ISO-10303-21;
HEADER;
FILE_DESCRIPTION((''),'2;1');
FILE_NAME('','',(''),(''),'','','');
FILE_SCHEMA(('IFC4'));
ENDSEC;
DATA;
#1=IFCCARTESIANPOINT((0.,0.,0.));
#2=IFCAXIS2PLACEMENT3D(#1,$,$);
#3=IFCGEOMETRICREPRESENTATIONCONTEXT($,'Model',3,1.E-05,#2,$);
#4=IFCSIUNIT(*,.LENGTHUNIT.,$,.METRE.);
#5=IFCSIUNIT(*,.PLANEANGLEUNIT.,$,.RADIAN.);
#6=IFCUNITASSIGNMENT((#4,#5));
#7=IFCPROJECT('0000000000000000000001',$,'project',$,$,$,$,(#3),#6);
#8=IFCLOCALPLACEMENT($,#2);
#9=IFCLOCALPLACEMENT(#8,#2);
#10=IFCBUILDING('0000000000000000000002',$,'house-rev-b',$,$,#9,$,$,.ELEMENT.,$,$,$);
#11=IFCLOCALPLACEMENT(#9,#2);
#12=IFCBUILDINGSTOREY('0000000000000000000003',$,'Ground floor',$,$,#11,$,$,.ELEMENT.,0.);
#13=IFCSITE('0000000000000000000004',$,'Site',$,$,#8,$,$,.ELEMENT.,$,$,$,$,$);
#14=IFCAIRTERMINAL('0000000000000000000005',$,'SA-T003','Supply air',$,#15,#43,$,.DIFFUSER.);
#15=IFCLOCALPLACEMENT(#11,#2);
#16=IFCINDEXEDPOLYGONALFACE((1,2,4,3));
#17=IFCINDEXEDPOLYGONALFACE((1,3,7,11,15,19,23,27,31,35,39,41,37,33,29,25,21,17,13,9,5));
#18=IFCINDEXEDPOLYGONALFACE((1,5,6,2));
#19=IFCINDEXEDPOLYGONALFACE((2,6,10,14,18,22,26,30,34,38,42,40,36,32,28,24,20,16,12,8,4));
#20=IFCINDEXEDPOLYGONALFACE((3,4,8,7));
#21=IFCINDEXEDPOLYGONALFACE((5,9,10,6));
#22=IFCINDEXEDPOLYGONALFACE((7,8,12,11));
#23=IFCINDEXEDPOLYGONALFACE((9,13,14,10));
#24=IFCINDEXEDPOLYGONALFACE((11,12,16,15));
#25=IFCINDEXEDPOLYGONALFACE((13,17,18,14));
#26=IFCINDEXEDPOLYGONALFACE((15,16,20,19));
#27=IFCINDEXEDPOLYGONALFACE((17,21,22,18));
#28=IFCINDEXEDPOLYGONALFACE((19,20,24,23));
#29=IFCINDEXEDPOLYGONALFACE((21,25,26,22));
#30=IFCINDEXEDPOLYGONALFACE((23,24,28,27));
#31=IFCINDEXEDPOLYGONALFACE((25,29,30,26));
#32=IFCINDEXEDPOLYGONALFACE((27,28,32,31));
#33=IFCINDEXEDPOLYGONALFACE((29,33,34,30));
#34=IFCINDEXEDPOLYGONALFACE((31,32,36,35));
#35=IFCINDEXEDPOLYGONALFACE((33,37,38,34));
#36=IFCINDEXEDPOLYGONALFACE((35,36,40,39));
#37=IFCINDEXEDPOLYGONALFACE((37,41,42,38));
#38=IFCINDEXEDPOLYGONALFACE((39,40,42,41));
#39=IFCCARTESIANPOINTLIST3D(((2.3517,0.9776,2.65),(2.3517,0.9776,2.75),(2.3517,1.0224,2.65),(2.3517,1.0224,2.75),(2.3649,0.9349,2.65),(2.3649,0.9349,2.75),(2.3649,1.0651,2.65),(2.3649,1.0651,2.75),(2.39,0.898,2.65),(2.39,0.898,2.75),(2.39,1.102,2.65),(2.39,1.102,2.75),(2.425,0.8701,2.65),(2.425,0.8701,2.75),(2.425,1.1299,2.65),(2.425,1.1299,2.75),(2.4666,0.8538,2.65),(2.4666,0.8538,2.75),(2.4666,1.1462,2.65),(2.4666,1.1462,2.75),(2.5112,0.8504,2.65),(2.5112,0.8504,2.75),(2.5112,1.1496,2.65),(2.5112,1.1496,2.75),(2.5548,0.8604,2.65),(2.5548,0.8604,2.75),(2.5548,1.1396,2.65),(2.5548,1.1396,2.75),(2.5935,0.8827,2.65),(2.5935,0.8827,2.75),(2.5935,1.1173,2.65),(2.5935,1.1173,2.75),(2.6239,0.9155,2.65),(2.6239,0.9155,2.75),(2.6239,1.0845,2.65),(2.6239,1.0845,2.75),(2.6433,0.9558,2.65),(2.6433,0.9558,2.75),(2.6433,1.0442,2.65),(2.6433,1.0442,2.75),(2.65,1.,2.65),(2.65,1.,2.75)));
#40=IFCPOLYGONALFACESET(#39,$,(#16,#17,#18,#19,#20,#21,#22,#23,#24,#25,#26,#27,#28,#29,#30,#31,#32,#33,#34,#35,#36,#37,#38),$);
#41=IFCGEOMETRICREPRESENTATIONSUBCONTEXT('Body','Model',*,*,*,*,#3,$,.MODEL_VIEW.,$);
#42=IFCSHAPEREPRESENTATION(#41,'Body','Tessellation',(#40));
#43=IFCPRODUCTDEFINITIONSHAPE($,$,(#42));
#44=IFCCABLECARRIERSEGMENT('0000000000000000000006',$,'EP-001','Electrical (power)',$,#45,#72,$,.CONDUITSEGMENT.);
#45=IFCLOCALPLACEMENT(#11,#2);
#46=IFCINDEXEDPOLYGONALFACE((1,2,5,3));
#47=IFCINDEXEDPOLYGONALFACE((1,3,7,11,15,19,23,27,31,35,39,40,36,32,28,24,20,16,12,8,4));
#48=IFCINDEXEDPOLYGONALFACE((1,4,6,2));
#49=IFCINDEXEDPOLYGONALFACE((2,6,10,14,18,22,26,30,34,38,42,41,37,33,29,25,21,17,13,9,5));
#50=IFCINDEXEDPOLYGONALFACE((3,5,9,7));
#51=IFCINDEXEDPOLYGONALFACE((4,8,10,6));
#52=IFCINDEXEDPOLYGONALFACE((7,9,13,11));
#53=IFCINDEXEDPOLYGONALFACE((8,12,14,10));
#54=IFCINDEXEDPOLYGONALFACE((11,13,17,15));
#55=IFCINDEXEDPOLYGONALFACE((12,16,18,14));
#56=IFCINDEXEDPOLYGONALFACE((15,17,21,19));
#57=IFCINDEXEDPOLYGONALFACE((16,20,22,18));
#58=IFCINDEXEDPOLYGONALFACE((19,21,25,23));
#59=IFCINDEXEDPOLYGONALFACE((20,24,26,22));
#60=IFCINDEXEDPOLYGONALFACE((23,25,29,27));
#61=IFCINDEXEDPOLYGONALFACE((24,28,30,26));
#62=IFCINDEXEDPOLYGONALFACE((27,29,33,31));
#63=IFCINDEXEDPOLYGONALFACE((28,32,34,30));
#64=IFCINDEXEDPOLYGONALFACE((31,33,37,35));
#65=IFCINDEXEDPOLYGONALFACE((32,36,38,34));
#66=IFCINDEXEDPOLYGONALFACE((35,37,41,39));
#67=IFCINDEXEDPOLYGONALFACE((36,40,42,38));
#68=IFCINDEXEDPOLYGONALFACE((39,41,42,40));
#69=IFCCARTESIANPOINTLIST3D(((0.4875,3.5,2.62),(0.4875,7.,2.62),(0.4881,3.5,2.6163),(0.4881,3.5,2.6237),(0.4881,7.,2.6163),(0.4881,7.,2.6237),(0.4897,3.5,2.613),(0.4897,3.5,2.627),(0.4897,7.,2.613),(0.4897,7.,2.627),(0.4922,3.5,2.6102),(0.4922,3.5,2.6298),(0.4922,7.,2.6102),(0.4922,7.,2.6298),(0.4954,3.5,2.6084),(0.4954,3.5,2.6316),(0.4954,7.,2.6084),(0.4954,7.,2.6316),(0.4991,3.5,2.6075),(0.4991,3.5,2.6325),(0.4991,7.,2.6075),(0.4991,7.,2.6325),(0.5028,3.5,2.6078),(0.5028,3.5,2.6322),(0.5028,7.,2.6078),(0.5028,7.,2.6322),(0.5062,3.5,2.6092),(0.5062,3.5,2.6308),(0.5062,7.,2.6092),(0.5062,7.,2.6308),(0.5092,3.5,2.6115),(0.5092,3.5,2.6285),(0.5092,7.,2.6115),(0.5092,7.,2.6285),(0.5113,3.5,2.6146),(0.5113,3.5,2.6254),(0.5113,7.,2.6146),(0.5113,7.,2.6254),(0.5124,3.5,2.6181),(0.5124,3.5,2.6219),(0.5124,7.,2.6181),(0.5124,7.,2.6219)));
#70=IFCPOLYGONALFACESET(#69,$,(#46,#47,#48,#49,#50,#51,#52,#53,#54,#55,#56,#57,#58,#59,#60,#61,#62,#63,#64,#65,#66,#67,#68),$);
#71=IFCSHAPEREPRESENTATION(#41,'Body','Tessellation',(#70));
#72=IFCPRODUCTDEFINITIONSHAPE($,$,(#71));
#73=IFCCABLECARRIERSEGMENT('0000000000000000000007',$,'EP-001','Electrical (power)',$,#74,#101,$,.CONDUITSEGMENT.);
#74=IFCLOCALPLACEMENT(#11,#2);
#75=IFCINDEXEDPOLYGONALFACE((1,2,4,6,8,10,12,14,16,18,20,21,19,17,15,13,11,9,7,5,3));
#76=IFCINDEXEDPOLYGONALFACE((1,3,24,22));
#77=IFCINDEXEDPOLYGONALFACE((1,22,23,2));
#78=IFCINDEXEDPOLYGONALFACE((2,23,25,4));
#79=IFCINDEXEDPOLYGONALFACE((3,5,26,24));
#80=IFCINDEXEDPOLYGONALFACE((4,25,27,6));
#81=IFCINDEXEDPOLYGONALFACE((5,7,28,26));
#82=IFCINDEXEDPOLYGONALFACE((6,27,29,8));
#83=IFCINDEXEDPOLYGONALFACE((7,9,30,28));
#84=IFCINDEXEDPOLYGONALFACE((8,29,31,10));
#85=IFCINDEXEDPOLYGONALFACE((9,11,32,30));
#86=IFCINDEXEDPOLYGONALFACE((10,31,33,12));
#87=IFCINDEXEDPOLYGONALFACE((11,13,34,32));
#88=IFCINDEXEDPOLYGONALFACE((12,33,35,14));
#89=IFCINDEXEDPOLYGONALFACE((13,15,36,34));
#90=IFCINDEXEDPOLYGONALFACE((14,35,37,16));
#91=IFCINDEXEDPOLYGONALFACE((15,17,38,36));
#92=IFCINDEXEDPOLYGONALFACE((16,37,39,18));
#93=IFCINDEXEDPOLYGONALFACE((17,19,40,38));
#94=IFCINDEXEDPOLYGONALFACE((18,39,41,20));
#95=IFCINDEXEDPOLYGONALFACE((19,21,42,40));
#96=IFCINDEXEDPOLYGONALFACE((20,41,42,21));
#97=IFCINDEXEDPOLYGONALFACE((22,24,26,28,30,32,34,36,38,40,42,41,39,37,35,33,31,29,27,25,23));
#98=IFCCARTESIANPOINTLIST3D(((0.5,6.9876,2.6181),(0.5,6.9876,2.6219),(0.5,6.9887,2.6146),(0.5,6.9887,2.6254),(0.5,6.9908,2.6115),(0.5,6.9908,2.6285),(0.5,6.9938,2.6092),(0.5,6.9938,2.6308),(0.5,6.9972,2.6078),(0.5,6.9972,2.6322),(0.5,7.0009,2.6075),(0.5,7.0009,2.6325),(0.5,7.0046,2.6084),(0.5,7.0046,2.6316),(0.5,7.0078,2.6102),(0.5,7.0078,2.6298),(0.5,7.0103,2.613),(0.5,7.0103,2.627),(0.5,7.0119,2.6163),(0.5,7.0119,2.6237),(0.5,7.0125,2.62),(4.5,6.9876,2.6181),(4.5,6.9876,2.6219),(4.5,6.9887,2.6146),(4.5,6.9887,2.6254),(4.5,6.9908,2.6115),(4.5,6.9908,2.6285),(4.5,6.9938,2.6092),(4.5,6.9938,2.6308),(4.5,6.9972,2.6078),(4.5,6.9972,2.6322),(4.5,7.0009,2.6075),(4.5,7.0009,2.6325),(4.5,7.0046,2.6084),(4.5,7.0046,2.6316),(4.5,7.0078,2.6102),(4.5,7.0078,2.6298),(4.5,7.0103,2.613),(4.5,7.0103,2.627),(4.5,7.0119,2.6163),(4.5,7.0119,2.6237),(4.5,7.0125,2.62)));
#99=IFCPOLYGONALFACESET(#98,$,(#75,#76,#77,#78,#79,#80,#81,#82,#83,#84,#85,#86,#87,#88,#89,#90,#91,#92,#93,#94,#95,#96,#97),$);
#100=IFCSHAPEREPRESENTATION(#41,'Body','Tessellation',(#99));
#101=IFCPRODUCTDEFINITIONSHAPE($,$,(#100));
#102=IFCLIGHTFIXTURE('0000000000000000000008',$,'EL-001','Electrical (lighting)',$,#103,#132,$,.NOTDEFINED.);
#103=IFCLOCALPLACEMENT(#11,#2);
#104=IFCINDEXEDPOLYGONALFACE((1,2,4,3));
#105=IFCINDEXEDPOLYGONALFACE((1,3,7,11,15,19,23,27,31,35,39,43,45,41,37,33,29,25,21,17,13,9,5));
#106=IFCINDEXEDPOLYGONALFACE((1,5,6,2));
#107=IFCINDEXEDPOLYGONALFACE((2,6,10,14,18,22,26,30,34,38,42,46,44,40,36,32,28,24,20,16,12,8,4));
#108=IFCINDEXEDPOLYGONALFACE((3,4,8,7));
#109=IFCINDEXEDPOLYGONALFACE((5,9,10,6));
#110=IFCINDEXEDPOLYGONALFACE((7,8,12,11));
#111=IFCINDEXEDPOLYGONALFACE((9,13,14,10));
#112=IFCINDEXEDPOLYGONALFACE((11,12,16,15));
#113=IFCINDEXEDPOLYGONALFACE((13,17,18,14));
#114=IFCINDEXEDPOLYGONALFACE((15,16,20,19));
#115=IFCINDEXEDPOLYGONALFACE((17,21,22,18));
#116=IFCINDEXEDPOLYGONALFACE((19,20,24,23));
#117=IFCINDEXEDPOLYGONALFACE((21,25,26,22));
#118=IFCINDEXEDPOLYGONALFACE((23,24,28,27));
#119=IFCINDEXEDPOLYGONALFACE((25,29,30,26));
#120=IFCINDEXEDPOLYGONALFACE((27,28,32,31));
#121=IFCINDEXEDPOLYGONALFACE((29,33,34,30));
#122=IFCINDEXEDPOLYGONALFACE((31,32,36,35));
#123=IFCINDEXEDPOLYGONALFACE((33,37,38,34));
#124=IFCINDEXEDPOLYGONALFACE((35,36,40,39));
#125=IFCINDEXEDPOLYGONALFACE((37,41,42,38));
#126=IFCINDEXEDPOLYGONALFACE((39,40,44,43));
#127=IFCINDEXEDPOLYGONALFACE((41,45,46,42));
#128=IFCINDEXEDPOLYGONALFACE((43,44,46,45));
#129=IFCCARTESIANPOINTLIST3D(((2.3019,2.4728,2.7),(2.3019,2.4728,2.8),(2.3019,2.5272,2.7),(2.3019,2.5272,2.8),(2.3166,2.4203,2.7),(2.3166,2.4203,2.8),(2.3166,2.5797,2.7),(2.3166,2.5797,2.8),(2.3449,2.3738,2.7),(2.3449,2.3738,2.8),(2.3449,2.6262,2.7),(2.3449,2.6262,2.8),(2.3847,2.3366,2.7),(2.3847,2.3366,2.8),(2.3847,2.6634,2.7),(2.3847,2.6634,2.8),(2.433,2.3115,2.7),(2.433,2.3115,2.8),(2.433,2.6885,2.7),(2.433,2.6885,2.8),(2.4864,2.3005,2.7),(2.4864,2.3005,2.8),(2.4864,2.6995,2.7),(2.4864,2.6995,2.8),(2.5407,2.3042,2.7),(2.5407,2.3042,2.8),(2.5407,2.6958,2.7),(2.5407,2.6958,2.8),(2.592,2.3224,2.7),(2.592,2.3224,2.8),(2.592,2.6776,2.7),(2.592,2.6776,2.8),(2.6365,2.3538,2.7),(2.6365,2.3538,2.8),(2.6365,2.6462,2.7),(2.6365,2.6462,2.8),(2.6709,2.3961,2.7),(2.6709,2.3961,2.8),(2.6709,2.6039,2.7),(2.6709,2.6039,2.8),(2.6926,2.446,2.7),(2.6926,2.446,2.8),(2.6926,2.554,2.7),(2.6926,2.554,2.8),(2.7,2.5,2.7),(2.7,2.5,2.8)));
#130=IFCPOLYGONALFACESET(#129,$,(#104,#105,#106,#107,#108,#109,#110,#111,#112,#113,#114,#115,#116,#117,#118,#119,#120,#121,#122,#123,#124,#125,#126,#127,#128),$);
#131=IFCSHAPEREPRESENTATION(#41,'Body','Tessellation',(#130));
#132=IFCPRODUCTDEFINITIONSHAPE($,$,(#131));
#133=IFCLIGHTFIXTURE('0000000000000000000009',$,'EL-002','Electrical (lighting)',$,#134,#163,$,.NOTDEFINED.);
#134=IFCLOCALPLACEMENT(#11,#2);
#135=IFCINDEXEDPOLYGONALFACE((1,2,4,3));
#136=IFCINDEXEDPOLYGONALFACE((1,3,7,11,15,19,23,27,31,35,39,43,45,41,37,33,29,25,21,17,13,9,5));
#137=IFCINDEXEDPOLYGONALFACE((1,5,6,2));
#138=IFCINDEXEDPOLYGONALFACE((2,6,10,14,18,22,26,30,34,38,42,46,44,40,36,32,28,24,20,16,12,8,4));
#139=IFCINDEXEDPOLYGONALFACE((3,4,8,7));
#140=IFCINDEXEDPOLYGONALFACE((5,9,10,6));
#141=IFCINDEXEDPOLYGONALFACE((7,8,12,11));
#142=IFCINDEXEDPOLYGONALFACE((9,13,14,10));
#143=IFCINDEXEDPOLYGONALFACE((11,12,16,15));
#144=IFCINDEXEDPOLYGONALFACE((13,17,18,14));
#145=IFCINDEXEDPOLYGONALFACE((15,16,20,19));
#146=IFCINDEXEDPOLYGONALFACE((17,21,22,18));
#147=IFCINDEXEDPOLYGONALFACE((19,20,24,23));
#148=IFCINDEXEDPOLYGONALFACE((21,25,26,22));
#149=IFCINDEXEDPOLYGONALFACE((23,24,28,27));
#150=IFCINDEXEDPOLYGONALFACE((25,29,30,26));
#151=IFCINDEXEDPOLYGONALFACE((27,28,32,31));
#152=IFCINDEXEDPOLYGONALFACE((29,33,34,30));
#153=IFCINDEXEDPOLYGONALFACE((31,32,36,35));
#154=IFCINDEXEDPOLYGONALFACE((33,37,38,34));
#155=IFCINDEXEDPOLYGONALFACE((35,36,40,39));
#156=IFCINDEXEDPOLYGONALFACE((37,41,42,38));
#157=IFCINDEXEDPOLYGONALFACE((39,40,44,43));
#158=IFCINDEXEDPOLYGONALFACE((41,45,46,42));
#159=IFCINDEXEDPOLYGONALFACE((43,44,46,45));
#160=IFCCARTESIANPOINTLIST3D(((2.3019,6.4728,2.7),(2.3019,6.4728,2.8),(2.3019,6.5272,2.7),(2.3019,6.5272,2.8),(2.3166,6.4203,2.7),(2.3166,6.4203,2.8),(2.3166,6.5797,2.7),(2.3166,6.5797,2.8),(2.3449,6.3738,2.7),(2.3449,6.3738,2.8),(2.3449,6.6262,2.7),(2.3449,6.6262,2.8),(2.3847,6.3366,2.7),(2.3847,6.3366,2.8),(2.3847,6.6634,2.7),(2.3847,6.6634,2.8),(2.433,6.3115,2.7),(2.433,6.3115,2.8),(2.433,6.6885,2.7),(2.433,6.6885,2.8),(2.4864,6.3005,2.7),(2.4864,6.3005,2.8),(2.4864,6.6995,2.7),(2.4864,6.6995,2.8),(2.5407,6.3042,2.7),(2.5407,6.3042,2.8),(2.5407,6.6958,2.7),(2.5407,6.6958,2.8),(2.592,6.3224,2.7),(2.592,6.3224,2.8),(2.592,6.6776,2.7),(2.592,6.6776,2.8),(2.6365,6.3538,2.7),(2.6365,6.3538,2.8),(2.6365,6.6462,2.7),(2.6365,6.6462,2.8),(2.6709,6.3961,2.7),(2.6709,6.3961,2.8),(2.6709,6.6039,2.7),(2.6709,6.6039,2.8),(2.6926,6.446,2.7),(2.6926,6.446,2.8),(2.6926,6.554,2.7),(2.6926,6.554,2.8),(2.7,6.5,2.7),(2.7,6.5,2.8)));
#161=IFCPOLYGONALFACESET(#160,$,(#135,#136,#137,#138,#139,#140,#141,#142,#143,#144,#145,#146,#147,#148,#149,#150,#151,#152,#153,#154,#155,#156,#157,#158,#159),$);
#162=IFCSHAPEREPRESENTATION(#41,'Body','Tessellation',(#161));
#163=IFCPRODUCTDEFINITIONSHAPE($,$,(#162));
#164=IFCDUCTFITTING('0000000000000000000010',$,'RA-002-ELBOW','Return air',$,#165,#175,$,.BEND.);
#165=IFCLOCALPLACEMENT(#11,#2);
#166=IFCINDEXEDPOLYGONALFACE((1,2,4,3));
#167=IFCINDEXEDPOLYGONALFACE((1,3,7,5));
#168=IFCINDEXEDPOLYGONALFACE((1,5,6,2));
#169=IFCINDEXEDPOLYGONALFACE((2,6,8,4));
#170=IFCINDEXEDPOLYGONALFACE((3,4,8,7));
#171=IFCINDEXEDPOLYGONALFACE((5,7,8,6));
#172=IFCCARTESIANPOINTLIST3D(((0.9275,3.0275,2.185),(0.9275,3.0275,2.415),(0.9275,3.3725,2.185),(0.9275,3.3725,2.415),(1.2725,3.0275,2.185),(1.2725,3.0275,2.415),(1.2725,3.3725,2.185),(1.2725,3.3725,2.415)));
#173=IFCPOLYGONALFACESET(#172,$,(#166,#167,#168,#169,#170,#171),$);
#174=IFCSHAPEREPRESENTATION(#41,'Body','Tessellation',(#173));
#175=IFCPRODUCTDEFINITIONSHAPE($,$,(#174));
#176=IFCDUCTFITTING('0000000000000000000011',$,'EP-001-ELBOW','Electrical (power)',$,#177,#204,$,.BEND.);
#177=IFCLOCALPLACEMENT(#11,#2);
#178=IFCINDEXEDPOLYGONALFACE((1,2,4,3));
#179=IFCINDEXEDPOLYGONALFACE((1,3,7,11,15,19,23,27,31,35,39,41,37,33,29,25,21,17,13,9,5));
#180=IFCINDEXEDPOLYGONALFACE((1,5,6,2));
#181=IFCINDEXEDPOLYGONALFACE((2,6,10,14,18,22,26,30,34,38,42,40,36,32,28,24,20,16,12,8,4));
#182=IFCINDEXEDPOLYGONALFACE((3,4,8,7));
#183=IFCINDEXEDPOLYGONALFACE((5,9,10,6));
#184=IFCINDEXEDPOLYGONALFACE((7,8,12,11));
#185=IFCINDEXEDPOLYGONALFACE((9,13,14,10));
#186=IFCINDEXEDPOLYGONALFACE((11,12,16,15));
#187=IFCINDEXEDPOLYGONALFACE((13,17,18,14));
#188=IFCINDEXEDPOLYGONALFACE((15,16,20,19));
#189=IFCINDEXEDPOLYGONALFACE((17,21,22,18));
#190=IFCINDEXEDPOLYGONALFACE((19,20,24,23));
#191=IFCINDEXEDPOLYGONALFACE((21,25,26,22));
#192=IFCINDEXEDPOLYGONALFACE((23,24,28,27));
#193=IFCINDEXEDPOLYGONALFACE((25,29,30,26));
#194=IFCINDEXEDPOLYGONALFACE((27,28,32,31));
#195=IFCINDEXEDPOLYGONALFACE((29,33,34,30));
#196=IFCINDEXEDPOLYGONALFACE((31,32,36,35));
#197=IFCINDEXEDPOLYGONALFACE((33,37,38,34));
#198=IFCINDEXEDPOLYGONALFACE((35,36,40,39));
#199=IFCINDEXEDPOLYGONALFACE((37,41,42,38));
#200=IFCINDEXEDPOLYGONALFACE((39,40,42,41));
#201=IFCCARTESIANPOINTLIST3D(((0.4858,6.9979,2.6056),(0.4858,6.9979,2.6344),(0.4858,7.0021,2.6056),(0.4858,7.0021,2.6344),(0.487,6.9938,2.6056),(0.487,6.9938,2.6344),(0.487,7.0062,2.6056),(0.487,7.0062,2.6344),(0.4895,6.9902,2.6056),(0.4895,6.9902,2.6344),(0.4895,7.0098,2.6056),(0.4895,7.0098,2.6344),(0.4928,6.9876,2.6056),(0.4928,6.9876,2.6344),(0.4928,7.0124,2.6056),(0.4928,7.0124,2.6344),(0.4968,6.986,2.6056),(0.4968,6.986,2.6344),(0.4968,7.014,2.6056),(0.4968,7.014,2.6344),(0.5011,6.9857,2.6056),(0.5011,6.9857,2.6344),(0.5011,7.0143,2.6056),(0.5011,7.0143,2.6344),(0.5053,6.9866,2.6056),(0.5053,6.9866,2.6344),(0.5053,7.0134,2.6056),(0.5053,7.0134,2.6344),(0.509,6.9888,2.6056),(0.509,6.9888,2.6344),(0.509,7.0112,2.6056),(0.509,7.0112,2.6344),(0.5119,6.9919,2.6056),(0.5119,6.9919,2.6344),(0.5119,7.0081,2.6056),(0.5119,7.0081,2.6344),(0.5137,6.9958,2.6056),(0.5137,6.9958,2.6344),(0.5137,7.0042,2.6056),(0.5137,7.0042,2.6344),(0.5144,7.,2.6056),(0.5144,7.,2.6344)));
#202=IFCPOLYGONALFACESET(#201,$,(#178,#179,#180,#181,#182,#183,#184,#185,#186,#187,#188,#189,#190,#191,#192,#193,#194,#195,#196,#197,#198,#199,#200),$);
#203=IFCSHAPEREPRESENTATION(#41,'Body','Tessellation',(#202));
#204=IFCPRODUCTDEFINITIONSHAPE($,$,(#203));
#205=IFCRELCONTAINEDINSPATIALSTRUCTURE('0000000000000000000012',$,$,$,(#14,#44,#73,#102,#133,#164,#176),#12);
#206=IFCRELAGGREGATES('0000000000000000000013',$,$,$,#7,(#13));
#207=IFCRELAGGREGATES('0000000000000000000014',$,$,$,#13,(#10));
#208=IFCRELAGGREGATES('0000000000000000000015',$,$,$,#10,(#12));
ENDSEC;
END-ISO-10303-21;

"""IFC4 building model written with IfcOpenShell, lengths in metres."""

from ifc_helpers import new_model, si_unit, frame, origin, origin_2d, place, context, subcontext, project, spatial, rectangle, circle, extrude, element, save


model = new_model("IFC4")

# Units and contexts
model_context = context("Model", 3, precision=1e-05, world=origin())
body_context = subcontext(model_context, "Body", "Model", "MODEL_VIEW")
ifc_project = project(units=[si_unit("LENGTHUNIT", "METRE"), si_unit("PLANEANGLEUNIT", "RADIAN")], contexts=[model_context])

# Site, building, storey
site_placement = place(None, origin())
site = spatial("IfcSite", under=ifc_project, at=site_placement, Name="Site", CompositionType="ELEMENT")
building_placement = place(site_placement, origin())
building = spatial("IfcBuilding", under=site, at=building_placement, Name="house-rev-b", CompositionType="ELEMENT")
storey_placement = place(building_placement, origin())
storey = spatial("IfcBuildingStorey", under=building, at=storey_placement, Name="Ground floor", CompositionType="ELEMENT", Elevation=0.0)

# Air terminal
air_terminal_placement = place(storey_placement, frame((2.5, 1.0, 2.65), z_axis=(0.0, 0.0, 1.0), x_axis=(1.0, 0.0, 0.0)))
element("IfcAirTerminal", 1, at=air_terminal_placement, inside=storey, Name="SA-T003", Description="Supply air", PredefinedType="DIFFUSER", context=body_context, shape_type="SweptSolid", body=[
    extrude(circle(Radius=0.15, at=origin_2d()), origin(), (0.0, 0.0, 1.0), 0.1),
])

# Cable carrier segments
cable_carrier_segment_1_placement = place(storey_placement, frame((0.5, 3.5, 2.62), z_axis=(0.0, 1.0, 0.0), x_axis=(-1.0, 0.0, 0.0)))
element("IfcCableCarrierSegment", 2, at=cable_carrier_segment_1_placement, inside=storey, Name="EP-001", Description="Electrical (power)", PredefinedType="CONDUITSEGMENT", context=body_context, shape_type="SweptSolid", body=[
    extrude(circle(Radius=0.0125, at=origin_2d()), origin(), (0.0, 0.0, 1.0), 3.5),
])
cable_carrier_segment_2_placement = place(storey_placement, frame((0.5, 7.0, 2.62), z_axis=(1.0, 0.0, 0.0), x_axis=(0.0, 1.0, 0.0)))
element("IfcCableCarrierSegment", 3, at=cable_carrier_segment_2_placement, inside=storey, Name="EP-001", Description="Electrical (power)", PredefinedType="CONDUITSEGMENT", context=body_context, shape_type="SweptSolid", body=[
    extrude(circle(Radius=0.0125, at=origin_2d()), origin(), (0.0, 0.0, 1.0), 4.0),
])

# Light fixtures
for number, where, z_axis, x_axis, name in (
    (4, (2.5, 2.5, 2.7), (0.0, 0.0, 1.0), (1.0, 0.0, 0.0), "EL-001"),
    (5, (2.5, 6.5, 2.7), (0.0, 0.0, 1.0), (1.0, 0.0, 0.0), "EL-002"),
):
    element("IfcLightFixture", number, at=place(storey_placement, frame(where, z_axis=z_axis, x_axis=x_axis)), inside=storey, Name=name, Description="Electrical (lighting)", PredefinedType="NOTDEFINED", context=body_context, shape_type="SweptSolid", body=[
        extrude(circle(Radius=0.2, at=origin_2d()), origin(), (0.0, 0.0, 1.0), 0.1),
    ])

# Duct fittings
duct_fitting_1_placement = place(storey_placement, frame((1.1, 3.2, 2.185), z_axis=(0.0, 0.0, 1.0), x_axis=(1.0, 0.0, 0.0)))
element("IfcDuctFitting", 6, at=duct_fitting_1_placement, inside=storey, Name="RA-002-ELBOW", Description="Return air", PredefinedType="BEND", context=body_context, shape_type="SweptSolid", body=[
    extrude(rectangle(XDim=0.345, YDim=0.345, at=origin_2d()), origin(), (0.0, 0.0, 1.0), 0.23),
])
duct_fitting_2_placement = place(storey_placement, frame((0.5, 7.0, 2.6056), z_axis=(0.0, 0.0, 1.0), x_axis=(1.0, 0.0, 0.0)))
element("IfcDuctFitting", 7, at=duct_fitting_2_placement, inside=storey, Name="EP-001-ELBOW", Description="Electrical (power)", PredefinedType="BEND", context=body_context, shape_type="SweptSolid", body=[
    extrude(circle(Radius=0.0144, at=origin_2d()), origin(), (0.0, 0.0, 1.0), 0.0288),
])

save(model, "model.ifc")
